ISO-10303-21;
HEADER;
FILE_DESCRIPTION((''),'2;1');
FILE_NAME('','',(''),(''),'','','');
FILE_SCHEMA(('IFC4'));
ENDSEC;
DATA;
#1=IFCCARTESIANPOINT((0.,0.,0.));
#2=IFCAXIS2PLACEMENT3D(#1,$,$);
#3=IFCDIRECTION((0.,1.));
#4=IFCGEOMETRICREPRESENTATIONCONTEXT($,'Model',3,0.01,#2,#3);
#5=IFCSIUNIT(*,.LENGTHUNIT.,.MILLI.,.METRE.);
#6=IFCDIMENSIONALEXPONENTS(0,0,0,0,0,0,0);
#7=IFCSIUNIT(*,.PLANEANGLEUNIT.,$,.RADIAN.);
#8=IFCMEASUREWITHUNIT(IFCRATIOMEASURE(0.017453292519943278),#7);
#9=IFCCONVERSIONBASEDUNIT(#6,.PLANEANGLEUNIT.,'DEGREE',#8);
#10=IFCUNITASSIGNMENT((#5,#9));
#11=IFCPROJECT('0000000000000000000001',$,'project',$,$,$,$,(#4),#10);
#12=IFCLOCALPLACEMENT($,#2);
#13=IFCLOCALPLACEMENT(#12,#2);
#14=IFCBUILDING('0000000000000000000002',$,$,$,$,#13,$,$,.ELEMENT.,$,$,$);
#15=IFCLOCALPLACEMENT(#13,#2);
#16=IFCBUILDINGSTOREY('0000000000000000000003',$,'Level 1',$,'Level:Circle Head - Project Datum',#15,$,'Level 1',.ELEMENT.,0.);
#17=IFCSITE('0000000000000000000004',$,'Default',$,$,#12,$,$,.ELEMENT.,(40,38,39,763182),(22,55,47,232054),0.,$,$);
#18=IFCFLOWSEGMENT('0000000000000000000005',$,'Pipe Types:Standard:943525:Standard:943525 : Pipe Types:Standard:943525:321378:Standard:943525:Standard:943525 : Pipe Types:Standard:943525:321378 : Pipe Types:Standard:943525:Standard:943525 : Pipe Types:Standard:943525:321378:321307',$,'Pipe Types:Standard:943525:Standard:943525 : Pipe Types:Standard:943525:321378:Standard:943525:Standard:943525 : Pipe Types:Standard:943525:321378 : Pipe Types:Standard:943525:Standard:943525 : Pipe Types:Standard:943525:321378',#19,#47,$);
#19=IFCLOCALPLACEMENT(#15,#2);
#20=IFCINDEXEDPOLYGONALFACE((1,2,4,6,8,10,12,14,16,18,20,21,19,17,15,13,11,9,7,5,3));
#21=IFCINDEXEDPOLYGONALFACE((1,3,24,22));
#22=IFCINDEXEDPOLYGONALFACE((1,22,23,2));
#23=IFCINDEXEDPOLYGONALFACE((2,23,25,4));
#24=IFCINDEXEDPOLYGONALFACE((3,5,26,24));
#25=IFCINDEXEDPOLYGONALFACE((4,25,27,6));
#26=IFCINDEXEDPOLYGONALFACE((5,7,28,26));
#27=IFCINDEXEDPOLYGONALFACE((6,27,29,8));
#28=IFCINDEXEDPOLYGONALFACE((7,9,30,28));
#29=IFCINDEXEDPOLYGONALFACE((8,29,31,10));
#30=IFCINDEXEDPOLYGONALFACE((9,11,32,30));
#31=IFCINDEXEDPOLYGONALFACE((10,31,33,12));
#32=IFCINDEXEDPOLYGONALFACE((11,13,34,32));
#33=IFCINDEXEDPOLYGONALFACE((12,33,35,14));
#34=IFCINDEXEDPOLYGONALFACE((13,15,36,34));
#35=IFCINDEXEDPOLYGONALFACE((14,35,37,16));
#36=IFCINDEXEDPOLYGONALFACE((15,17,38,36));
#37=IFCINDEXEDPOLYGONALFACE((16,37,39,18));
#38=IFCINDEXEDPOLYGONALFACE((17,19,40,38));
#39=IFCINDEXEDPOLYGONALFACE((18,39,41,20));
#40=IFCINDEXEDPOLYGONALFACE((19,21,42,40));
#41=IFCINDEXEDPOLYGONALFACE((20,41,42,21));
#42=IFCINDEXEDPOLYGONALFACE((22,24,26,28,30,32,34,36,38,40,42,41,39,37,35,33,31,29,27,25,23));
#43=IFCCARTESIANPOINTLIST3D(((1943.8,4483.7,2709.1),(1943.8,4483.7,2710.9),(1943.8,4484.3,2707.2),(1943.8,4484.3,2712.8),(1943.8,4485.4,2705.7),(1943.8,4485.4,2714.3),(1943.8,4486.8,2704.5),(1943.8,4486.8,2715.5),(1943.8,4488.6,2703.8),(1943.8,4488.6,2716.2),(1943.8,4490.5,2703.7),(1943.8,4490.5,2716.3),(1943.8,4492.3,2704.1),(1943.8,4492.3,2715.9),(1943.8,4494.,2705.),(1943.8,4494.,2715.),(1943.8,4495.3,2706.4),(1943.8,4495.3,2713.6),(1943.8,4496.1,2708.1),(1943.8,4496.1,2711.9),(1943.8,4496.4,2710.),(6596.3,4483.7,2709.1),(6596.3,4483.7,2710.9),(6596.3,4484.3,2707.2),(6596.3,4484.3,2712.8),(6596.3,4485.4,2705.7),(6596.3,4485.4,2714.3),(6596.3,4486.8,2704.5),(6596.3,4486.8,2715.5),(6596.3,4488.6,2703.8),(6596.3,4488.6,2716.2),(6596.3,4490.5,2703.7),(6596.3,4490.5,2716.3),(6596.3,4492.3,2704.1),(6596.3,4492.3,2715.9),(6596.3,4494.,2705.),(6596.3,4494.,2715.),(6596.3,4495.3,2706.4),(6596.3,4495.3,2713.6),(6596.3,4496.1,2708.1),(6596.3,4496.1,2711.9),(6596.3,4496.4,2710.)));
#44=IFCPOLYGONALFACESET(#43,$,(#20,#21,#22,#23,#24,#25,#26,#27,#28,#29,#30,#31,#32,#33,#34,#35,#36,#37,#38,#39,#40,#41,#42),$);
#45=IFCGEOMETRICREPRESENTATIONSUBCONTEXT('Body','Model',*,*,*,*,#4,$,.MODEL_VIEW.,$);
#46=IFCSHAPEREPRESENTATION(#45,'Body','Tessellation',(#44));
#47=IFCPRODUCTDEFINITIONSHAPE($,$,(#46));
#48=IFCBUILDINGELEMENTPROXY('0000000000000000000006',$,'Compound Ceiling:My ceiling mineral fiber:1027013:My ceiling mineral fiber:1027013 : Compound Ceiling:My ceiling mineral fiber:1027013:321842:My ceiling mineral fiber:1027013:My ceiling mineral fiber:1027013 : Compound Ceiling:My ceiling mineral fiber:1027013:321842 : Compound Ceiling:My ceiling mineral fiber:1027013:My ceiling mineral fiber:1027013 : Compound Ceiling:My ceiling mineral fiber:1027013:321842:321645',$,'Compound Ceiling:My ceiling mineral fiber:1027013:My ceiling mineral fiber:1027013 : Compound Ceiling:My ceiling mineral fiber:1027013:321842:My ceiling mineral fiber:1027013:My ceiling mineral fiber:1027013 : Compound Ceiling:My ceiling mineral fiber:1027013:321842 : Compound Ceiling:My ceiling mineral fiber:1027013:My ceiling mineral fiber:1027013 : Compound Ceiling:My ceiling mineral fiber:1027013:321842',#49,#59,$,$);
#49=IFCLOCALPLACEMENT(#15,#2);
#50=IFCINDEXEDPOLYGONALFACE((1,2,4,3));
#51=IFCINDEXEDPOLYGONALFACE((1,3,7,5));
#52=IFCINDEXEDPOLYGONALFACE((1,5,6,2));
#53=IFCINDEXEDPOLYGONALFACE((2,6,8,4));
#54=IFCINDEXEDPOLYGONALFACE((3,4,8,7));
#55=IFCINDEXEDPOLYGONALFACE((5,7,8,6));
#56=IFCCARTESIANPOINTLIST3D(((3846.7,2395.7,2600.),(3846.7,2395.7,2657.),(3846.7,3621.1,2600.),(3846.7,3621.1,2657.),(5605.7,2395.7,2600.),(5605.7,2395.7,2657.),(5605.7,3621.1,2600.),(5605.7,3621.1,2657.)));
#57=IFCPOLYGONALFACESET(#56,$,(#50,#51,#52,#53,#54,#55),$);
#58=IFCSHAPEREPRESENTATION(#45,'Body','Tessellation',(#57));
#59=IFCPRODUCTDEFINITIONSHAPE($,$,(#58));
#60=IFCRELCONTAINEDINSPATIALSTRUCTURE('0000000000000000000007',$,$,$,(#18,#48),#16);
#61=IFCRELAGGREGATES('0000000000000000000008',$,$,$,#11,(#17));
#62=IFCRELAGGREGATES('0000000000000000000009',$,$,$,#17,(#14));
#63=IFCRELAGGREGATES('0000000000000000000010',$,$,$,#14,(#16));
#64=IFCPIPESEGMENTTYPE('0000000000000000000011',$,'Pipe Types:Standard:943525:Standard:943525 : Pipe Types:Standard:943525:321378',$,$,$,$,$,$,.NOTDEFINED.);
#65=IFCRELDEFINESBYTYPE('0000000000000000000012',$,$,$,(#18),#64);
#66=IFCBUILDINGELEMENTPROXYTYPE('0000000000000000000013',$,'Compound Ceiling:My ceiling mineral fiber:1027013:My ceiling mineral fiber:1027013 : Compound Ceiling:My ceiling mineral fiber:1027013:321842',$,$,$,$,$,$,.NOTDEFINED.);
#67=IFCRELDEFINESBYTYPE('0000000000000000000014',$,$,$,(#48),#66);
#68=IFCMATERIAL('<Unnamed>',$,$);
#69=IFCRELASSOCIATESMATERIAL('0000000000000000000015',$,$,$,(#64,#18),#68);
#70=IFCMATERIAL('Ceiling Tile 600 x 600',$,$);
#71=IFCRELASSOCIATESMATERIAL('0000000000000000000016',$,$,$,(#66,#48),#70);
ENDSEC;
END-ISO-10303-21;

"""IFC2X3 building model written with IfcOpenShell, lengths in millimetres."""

from ifc_helpers import new_model, entity, si_unit, converted_unit, direction, frame, frame_2d, origin, origin_2d_with_axis, place, context, subcontext, project, spatial, rectangle, circle, extrude, source, transform, mapped, material, type_object, type_shapes, element, save


model = new_model("IFC2X3")

# Units and contexts
model_context = context("Model", 3, precision=0.01, world=origin(), true_north=direction((0.0, 1.0)))
body_context = subcontext(model_context, "Body", "Model", "MODEL_VIEW")
ifc_project = project(units=[si_unit("LENGTHUNIT", "METRE", prefix="MILLI"), converted_unit("PLANEANGLEUNIT", "DEGREE", entity("IfcRatioMeasure", 0.017453292519943278), si_unit("PLANEANGLEUNIT", "RADIAN"), dimensions=[0, 0, 0, 0, 0, 0, 0])], contexts=[model_context])

# Site, building, storey
site_placement = place(None, origin())
site = spatial("IfcSite", under=ifc_project, at=site_placement, Name="Default", CompositionType="ELEMENT", RefLatitude=(40, 38, 39, 763182), RefLongitude=(22, 55, 47, 232054), RefElevation=0.0)
building_placement = place(site_placement, origin())
building = spatial("IfcBuilding", under=site, at=building_placement, CompositionType="ELEMENT")
storey_placement = place(building_placement, origin())
storey = spatial("IfcBuildingStorey", under=building, at=storey_placement, Name="Level 1", ObjectType="Level:Circle Head - Project Datum", LongName="Level 1", CompositionType="ELEMENT", Elevation=0.0)

# Flow segment
ifc_material_1 = material(Name="<Unnamed>")
pipe_segment_type_1 = type_object("IfcPipeSegmentType", Name="Pipe Types:Standard:943525:Standard:943525 : Pipe Types:Standard:943525:321378", PredefinedType="NOTDEFINED", material=ifc_material_1)
shared_shape_1 = source(origin(), body_context, "Body", "SweptSolid", [
    extrude(circle(Radius=6.3, at=origin_2d_with_axis()), frame((1943.8, 4490.0, 2710.0), z_axis=(1.0, 0.0, 0.0), x_axis=(0.0, 1.0, 0.0)), (0.0, 0.0, 1.0), 4652.5),
])
type_shapes(pipe_segment_type_1, [shared_shape_1])
flow_segment_1_placement = place(storey_placement, origin())
element("IfcFlowSegment", 1, at=flow_segment_1_placement, inside=storey, type_object=pipe_segment_type_1, material=ifc_material_1, Name="Pipe Types:Standard:943525:Standard:943525 : Pipe Types:Standard:943525:321378:Standard:943525:Standard:943525 : Pipe Types:Standard:943525:321378 : Pipe Types:Standard:943525:Standard:943525 : Pipe Types:Standard:943525:321378:321307", ObjectType="Pipe Types:Standard:943525:Standard:943525 : Pipe Types:Standard:943525:321378:Standard:943525:Standard:943525 : Pipe Types:Standard:943525:321378 : Pipe Types:Standard:943525:Standard:943525 : Pipe Types:Standard:943525:321378", context=body_context, shape_type="MappedRepresentation", body=[
    mapped(shared_shape_1, transform((0.0, 0.0, 0.0), scale=1.0)),
])

# Building element proxy
ifc_material_2 = material(Name="Ceiling Tile 600 x 600")
building_element_proxy_type_1 = type_object("IfcBuildingElementProxyType", Name="Compound Ceiling:My ceiling mineral fiber:1027013:My ceiling mineral fiber:1027013 : Compound Ceiling:My ceiling mineral fiber:1027013:321842", PredefinedType="NOTDEFINED", material=ifc_material_2)
shared_shape_2 = source(origin(), body_context, "Body", "SweptSolid", [
    extrude(rectangle(XDim=1759.0, YDim=1225.5, at=frame_2d((0.0, 0.0), x_axis=(1.0, 0.0))), frame((4726.2, 3008.4, 2600.0)), (0.0, 0.0, 1.0), 57.0),
])
type_shapes(building_element_proxy_type_1, [shared_shape_2])
proxy_1_placement = place(storey_placement, origin())
element("IfcBuildingElementProxy", 2, at=proxy_1_placement, inside=storey, type_object=building_element_proxy_type_1, material=ifc_material_2, Name="Compound Ceiling:My ceiling mineral fiber:1027013:My ceiling mineral fiber:1027013 : Compound Ceiling:My ceiling mineral fiber:1027013:321842:My ceiling mineral fiber:1027013:My ceiling mineral fiber:1027013 : Compound Ceiling:My ceiling mineral fiber:1027013:321842 : Compound Ceiling:My ceiling mineral fiber:1027013:My ceiling mineral fiber:1027013 : Compound Ceiling:My ceiling mineral fiber:1027013:321842:321645", ObjectType="Compound Ceiling:My ceiling mineral fiber:1027013:My ceiling mineral fiber:1027013 : Compound Ceiling:My ceiling mineral fiber:1027013:321842:My ceiling mineral fiber:1027013:My ceiling mineral fiber:1027013 : Compound Ceiling:My ceiling mineral fiber:1027013:321842 : Compound Ceiling:My ceiling mineral fiber:1027013:My ceiling mineral fiber:1027013 : Compound Ceiling:My ceiling mineral fiber:1027013:321842", context=body_context, shape_type="MappedRepresentation", body=[
    mapped(shared_shape_2, transform((0.0, 0.0, 0.0), scale=1.0)),
])

save(model, "model.ifc")
